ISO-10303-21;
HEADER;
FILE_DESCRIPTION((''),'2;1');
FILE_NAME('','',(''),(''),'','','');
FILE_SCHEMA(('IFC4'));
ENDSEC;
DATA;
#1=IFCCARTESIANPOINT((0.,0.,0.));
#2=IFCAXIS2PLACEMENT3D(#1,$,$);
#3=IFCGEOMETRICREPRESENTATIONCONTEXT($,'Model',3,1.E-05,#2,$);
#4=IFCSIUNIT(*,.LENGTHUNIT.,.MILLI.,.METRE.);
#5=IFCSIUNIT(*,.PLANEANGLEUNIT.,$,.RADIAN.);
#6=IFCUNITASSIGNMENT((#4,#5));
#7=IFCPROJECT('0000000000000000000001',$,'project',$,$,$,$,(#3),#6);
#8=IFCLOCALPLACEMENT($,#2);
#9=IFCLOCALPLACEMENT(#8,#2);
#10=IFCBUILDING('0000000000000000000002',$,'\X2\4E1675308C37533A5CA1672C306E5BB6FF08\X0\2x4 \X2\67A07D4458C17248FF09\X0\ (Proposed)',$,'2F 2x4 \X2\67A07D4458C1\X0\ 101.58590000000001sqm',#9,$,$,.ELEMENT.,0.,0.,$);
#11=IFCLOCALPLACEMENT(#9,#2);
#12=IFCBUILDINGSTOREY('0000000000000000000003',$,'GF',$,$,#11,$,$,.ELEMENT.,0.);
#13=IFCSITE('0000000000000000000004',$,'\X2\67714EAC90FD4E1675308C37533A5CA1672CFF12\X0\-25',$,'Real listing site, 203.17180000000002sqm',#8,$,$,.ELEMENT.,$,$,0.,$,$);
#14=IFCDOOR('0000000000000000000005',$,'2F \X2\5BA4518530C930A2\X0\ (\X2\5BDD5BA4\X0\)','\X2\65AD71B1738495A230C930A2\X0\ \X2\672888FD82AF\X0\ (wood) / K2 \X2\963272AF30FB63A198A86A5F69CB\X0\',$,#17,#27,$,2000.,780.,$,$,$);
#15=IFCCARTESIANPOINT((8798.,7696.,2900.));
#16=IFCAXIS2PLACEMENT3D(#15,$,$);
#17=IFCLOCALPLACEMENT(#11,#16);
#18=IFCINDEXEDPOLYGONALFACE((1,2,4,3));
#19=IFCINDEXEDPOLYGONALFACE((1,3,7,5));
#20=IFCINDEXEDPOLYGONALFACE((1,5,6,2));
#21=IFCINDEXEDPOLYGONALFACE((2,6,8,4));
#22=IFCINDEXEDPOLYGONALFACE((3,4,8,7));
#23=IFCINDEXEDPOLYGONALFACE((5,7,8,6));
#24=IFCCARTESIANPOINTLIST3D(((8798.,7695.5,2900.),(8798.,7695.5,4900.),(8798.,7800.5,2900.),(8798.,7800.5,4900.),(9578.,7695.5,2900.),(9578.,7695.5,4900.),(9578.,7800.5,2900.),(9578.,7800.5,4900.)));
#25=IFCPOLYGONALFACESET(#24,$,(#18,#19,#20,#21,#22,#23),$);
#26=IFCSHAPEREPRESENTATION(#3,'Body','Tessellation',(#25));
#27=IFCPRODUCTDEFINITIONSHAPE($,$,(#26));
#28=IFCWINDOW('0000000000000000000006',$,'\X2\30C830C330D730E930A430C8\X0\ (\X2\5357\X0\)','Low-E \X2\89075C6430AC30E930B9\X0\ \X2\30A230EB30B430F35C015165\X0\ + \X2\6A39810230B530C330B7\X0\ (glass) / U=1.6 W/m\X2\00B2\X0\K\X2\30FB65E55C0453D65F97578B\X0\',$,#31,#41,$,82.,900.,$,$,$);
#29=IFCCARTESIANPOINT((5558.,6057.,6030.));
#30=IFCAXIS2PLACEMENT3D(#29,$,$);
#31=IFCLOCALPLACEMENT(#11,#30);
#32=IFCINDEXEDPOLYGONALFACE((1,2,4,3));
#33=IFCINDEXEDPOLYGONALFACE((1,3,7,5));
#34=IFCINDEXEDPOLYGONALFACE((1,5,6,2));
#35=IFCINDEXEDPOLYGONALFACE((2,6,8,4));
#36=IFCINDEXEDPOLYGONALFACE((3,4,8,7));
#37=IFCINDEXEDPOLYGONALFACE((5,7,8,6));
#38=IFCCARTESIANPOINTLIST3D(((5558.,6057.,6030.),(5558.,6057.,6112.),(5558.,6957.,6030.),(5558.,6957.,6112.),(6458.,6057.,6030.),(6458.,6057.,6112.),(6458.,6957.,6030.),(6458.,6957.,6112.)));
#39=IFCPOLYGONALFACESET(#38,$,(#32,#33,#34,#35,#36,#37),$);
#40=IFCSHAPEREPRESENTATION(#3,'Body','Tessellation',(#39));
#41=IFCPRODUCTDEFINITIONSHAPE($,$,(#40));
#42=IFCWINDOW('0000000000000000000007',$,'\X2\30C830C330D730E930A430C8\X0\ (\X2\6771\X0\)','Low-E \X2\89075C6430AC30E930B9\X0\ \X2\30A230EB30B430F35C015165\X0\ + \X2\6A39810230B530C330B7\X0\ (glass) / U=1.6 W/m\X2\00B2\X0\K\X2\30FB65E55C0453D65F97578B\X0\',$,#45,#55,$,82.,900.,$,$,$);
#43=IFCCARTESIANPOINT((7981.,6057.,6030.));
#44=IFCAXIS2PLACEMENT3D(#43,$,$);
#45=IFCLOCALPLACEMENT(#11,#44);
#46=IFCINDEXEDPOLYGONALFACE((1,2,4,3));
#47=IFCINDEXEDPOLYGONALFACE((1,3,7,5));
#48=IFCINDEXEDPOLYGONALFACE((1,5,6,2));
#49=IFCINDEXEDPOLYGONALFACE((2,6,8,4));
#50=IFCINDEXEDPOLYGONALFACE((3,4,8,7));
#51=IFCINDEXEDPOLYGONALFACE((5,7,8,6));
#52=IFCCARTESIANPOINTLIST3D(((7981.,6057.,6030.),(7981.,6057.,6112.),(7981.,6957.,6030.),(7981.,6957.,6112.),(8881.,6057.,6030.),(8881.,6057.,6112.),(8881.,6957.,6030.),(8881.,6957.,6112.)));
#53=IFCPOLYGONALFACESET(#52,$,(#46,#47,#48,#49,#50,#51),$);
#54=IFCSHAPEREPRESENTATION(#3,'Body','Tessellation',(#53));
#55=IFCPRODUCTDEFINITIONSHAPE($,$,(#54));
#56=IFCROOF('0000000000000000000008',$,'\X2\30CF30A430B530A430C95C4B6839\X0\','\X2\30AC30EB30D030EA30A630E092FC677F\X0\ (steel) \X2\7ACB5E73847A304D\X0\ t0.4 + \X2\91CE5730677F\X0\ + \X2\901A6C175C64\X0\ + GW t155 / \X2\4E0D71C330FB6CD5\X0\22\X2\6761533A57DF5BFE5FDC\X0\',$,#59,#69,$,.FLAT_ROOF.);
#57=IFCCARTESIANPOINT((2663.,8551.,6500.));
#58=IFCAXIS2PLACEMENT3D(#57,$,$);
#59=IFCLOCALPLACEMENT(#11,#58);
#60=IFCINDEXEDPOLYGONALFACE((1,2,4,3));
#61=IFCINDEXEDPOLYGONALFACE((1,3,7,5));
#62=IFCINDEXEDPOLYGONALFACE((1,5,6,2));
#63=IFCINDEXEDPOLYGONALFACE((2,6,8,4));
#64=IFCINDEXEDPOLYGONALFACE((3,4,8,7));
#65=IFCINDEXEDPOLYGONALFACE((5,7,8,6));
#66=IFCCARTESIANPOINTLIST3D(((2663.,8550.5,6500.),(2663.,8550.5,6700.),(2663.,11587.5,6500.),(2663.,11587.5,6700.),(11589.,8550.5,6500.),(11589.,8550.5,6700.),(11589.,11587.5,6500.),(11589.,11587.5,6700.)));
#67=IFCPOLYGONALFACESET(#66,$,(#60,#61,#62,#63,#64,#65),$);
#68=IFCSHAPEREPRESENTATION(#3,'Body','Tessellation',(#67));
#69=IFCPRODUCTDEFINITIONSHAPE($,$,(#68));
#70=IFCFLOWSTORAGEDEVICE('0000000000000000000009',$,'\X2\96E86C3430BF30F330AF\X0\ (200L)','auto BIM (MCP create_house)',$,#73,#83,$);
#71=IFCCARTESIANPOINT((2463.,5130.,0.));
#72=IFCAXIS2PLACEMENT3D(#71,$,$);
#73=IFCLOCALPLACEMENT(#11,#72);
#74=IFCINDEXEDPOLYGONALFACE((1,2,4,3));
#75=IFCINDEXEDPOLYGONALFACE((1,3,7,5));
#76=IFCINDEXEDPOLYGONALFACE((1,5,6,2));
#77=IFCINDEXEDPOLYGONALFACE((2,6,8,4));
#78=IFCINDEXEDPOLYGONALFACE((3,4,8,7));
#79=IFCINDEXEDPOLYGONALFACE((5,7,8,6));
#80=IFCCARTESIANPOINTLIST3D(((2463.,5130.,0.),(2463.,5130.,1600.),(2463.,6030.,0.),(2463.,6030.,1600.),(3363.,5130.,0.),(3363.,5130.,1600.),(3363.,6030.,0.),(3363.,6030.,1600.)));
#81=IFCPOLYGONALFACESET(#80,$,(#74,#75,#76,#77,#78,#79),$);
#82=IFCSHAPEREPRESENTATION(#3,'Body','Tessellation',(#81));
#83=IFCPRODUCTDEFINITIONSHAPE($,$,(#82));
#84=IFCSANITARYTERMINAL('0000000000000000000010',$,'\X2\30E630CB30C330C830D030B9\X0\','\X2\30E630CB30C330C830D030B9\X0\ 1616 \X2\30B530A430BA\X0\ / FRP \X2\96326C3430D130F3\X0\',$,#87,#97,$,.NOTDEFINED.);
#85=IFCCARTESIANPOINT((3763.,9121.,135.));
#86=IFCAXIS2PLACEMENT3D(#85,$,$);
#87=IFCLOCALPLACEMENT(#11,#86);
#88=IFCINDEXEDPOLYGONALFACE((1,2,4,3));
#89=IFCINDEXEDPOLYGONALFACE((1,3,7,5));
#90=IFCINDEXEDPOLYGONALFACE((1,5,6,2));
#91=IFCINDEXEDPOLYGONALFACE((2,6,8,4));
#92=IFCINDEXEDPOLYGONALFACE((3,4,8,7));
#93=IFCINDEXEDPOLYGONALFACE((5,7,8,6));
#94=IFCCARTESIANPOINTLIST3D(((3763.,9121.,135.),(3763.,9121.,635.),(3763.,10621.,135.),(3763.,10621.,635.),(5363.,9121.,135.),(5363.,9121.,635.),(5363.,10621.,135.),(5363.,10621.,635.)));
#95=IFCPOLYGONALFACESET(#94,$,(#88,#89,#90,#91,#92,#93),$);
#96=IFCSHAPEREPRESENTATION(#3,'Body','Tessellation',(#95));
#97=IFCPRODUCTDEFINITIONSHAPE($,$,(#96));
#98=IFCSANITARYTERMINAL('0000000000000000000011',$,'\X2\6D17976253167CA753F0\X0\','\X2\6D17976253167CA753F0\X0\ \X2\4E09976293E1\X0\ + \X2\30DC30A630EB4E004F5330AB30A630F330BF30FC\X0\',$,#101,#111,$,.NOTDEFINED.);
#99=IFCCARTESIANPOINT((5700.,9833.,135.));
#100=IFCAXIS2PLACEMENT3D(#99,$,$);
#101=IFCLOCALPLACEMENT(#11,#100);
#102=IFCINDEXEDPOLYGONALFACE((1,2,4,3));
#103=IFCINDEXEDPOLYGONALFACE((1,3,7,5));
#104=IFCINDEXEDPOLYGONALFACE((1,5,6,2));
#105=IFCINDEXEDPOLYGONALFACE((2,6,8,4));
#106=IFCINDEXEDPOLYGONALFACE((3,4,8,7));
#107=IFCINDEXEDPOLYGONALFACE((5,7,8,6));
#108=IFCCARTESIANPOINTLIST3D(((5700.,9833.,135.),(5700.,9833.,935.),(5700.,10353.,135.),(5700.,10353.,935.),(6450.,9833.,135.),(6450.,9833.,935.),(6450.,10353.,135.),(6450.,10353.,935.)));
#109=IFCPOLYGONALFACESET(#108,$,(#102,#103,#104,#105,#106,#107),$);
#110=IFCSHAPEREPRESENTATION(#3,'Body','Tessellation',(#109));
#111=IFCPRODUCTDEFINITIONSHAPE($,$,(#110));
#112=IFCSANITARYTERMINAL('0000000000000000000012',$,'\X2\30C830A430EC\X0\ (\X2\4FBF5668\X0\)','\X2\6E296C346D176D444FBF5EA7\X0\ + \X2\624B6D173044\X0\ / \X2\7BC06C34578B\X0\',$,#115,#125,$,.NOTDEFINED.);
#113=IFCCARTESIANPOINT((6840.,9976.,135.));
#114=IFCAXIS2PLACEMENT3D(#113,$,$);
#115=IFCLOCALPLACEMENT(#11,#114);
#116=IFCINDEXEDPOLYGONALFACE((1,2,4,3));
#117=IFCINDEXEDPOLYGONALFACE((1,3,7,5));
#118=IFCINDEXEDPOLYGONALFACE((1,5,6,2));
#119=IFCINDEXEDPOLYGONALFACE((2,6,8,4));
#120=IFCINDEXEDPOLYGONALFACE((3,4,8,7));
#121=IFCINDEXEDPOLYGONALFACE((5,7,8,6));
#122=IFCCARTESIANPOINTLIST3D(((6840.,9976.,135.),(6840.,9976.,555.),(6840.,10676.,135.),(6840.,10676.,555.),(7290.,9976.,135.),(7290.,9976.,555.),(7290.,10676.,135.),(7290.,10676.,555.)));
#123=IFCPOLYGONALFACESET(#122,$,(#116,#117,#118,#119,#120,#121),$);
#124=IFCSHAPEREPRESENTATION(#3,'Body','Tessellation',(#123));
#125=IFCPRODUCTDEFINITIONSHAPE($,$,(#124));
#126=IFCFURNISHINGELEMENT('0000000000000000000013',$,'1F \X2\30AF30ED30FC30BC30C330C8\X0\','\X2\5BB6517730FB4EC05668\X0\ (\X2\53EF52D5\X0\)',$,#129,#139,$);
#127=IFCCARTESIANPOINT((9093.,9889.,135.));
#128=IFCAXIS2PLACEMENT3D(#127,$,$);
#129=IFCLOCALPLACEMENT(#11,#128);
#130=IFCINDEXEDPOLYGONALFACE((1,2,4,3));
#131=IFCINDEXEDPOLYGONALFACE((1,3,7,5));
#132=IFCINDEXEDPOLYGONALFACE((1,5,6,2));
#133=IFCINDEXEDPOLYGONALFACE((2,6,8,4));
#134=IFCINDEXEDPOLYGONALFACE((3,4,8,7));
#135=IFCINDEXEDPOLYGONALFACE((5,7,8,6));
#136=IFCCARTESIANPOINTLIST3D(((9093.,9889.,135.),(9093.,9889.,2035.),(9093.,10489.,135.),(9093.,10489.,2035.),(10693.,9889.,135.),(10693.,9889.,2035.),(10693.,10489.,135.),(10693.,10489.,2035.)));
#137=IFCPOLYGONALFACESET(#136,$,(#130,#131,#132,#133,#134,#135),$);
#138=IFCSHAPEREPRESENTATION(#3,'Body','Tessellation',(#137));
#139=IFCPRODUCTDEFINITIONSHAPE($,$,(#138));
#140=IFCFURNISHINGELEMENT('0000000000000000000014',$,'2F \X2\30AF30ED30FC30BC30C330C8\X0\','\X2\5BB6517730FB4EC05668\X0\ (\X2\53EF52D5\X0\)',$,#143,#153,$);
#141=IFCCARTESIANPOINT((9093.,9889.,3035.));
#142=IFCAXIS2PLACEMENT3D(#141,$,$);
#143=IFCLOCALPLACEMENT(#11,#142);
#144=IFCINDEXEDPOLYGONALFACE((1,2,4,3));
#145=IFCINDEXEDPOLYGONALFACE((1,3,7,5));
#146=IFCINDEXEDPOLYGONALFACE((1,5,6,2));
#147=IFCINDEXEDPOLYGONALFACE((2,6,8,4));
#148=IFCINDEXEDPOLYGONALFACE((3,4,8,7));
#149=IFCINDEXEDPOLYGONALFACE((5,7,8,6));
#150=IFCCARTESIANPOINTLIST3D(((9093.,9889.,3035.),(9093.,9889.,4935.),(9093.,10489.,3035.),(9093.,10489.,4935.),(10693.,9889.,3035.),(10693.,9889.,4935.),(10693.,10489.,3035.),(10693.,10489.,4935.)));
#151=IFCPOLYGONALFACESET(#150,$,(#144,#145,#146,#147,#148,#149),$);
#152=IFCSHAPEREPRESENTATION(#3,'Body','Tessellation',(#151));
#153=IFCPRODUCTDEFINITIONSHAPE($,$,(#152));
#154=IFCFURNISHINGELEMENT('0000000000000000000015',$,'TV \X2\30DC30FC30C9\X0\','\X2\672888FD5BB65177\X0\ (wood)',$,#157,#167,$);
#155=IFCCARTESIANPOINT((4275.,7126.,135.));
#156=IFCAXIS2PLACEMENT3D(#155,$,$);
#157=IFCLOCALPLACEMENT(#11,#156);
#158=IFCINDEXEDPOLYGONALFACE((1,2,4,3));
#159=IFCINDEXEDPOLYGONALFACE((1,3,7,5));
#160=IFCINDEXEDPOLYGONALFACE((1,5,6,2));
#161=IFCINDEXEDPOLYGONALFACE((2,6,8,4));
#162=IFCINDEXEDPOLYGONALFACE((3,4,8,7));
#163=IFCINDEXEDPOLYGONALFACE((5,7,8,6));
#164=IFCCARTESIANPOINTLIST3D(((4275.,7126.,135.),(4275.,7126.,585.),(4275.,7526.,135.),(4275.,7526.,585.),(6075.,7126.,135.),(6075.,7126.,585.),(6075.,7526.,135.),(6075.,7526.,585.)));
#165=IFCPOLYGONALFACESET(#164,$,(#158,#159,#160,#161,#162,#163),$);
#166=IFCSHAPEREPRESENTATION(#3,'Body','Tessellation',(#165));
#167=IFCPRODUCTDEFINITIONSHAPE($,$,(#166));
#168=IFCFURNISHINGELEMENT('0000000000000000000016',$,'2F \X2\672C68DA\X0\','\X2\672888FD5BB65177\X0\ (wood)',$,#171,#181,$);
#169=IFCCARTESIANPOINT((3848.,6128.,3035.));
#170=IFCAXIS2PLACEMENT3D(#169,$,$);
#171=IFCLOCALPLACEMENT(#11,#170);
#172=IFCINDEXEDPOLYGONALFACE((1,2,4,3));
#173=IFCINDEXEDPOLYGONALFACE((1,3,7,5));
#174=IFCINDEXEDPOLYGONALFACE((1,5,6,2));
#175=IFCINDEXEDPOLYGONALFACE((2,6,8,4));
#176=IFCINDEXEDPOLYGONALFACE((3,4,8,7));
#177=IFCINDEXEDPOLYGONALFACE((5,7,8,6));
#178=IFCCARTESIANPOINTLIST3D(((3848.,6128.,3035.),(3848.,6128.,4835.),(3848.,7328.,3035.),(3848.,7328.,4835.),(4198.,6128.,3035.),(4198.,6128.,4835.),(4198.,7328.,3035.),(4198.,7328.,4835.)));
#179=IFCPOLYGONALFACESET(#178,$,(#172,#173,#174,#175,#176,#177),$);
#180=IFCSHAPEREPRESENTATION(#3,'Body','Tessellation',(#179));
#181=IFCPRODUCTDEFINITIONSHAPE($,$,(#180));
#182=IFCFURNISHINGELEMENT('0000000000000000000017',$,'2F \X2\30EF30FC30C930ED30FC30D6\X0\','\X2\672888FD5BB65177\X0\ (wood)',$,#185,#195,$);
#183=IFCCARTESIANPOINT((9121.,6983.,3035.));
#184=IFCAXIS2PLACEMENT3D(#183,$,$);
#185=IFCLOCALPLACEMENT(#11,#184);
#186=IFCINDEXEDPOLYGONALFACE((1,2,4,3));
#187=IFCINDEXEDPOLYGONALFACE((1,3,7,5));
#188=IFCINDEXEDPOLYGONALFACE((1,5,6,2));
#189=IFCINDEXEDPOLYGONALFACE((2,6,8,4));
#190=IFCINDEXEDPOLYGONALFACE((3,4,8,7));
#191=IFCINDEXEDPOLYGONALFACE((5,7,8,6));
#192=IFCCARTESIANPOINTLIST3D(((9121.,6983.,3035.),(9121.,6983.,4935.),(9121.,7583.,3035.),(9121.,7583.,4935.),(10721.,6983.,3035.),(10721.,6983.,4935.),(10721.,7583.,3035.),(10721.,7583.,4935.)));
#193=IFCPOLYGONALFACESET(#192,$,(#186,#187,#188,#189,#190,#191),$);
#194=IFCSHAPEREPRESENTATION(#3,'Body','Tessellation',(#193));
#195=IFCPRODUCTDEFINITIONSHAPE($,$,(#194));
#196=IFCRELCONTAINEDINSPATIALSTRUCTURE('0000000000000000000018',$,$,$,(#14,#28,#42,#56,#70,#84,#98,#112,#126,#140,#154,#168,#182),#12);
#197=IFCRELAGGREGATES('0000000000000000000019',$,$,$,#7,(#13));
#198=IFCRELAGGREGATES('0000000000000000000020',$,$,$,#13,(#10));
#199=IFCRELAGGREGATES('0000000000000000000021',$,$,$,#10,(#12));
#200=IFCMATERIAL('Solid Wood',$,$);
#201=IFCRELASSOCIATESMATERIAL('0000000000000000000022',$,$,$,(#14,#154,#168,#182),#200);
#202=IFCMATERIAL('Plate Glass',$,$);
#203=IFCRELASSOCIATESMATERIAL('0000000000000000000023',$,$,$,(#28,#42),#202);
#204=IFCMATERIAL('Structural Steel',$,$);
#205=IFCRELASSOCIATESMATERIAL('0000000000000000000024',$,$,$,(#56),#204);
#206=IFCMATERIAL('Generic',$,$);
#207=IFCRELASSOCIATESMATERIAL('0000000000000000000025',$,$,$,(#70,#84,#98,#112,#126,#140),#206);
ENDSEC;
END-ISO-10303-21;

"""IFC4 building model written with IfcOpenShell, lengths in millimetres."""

from ifc_helpers import new_model, si_unit, frame, frame_2d, origin, place, context, project, spatial, rectangle, extrude, material, element, save


model = new_model("IFC4")

# Units and contexts
model_context = context("Model", 3, precision=1e-05, world=origin())
ifc_project = project(units=[si_unit("LENGTHUNIT", "METRE", prefix="MILLI"), si_unit("PLANEANGLEUNIT", "RADIAN")], contexts=[model_context])

# Site, building, storey
site_placement = place(None, origin())
site = spatial("IfcSite", under=ifc_project, at=site_placement, Name="東京都世田谷区岡本２-25", ObjectType="Real listing site, 203.17180000000002sqm", CompositionType="ELEMENT", RefElevation=0.0)
building_placement = place(site_placement, origin())
building = spatial("IfcBuilding", under=site, at=building_placement, Name="世田谷区岡本の家（2x4 枠組壁版） (Proposed)", ObjectType="2F 2x4 枠組壁 101.58590000000001sqm", CompositionType="ELEMENT", ElevationOfRefHeight=0.0, ElevationOfTerrain=0.0)
storey_placement = place(building_placement, origin())
storey = spatial("IfcBuildingStorey", under=building, at=storey_placement, Name="GF", CompositionType="ELEMENT", Elevation=0.0)

# Shared definitions
ifc_material_1 = material(Name="Solid Wood")
ifc_material_2 = material(Name="Plate Glass")

# Door
door_1_placement = place(storey_placement, frame((8798.0, 7696.0, 2900.0)))
element("IfcDoor", 1, at=door_1_placement, inside=storey, material=ifc_material_1, Name="2F 室内ドア (寝室)", Description="断熱玄関ドア 木製芯 (wood) / K2 防犯・採風機構", OverallHeight=2000.0, OverallWidth=780.0, context=model_context, shape_type="SweptSolid", body=[
    extrude(rectangle(XDim=780.0, YDim=105.0, at=frame_2d((390.0, 52.0))), frame((8798.0, 7696.0, 2900.0)), (0.0, 0.0, 1.0), 2000.0),
])

# Windows
window_1_placement = place(storey_placement, frame((5558.0, 6057.0, 6030.0)))
element("IfcWindow", 2, at=window_1_placement, inside=storey, material=ifc_material_2, Name="トップライト (南)", Description="Low-E 複層ガラス アルゴン封入 + 樹脂サッシ (glass) / U=1.6 W/m²K・日射取得型", OverallHeight=82.0, OverallWidth=900.0, context=model_context, shape_type="SweptSolid", body=[
    extrude(rectangle(XDim=900.0, YDim=900.0, at=frame_2d((450.0, 450.0))), frame((5558.0, 6057.0, 6030.0)), (0.0, 0.0, 1.0), 82.0),
])
window_2_placement = place(storey_placement, frame((7981.0, 6057.0, 6030.0)))
element("IfcWindow", 3, at=window_2_placement, inside=storey, material=ifc_material_2, Name="トップライト (東)", Description="Low-E 複層ガラス アルゴン封入 + 樹脂サッシ (glass) / U=1.6 W/m²K・日射取得型", OverallHeight=82.0, OverallWidth=900.0, context=model_context, shape_type="SweptSolid", body=[
    extrude(rectangle(XDim=900.0, YDim=900.0, at=frame_2d((450.0, 450.0))), frame((7981.0, 6057.0, 6030.0)), (0.0, 0.0, 1.0), 82.0),
])

# Roof
ifc_material_3 = material(Name="Structural Steel")
roof_placement = place(storey_placement, frame((2663.0, 8551.0, 6500.0)))
element("IfcRoof", 4, at=roof_placement, inside=storey, material=ifc_material_3, Name="ハイサイド屋根", Description="ガルバリウム鋼板 (steel) 立平葺き t0.4 + 野地板 + 通気層 + GW t155 / 不燃・法22条区域対応", PredefinedType="FLAT_ROOF", context=model_context, shape_type="SweptSolid", body=[
    extrude(rectangle(XDim=8926.0, YDim=3037.0, at=frame_2d((4463.0, 1518.0))), frame((2663.0, 8551.0, 6500.0)), (0.0, 0.0, 1.0), 200.0),
])

# Flow storage device
ifc_material_4 = material(Name="Generic")
flow_storage_device_placement = place(storey_placement, frame((2463.0, 5130.0, 0.0)))
element("IfcFlowStorageDevice", 5, at=flow_storage_device_placement, inside=storey, material=ifc_material_4, Name="雨水タンク (200L)", Description="auto BIM (MCP create_house)", context=model_context, shape_type="SweptSolid", body=[
    extrude(rectangle(XDim=900.0, YDim=900.0, at=frame_2d((450.0, 450.0))), frame((2463.0, 5130.0, 0.0)), (0.0, 0.0, 1.0), 1600.0),
])

# Sanitary terminals
sanitary_terminal_1_placement = place(storey_placement, frame((3763.0, 9121.0, 135.0)))
element("IfcSanitaryTerminal", 6, at=sanitary_terminal_1_placement, inside=storey, material=ifc_material_4, Name="ユニットバス", Description="ユニットバス 1616 サイズ / FRP 防水パン", PredefinedType="NOTDEFINED", context=model_context, shape_type="SweptSolid", body=[
    extrude(rectangle(XDim=1600.0, YDim=1500.0, at=frame_2d((800.0, 750.0))), frame((3763.0, 9121.0, 135.0)), (0.0, 0.0, 1.0), 500.0),
])
sanitary_terminal_2_placement = place(storey_placement, frame((5700.0, 9833.0, 135.0)))
element("IfcSanitaryTerminal", 7, at=sanitary_terminal_2_placement, inside=storey, material=ifc_material_4, Name="洗面化粧台", Description="洗面化粧台 三面鏡 + ボウル一体カウンター", PredefinedType="NOTDEFINED", context=model_context, shape_type="SweptSolid", body=[
    extrude(rectangle(XDim=750.0, YDim=520.0, at=frame_2d((375.0, 260.0))), frame((5700.0, 9833.0, 135.0)), (0.0, 0.0, 1.0), 800.0),
])
sanitary_terminal_3_placement = place(storey_placement, frame((6840.0, 9976.0, 135.0)))
element("IfcSanitaryTerminal", 8, at=sanitary_terminal_3_placement, inside=storey, material=ifc_material_4, Name="トイレ (便器)", Description="温水洗浄便座 + 手洗い / 節水型", PredefinedType="NOTDEFINED", context=model_context, shape_type="SweptSolid", body=[
    extrude(rectangle(XDim=450.0, YDim=700.0, at=frame_2d((225.0, 350.0))), frame((6840.0, 9976.0, 135.0)), (0.0, 0.0, 1.0), 420.0),
])

# Furnishing elements
furnishing_1_placement = place(storey_placement, frame((9093.0, 9889.0, 135.0)))
element("IfcFurnishingElement", 9, at=furnishing_1_placement, inside=storey, material=ifc_material_4, Name="1F クローゼット", Description="家具・什器 (可動)", context=model_context, shape_type="SweptSolid", body=[
    extrude(rectangle(XDim=1600.0, YDim=600.0, at=frame_2d((800.0, 300.0))), frame((9093.0, 9889.0, 135.0)), (0.0, 0.0, 1.0), 1900.0),
])
furnishing_2_placement = place(storey_placement, frame((9093.0, 9889.0, 3035.0)))
element("IfcFurnishingElement", 10, at=furnishing_2_placement, inside=storey, material=ifc_material_4, Name="2F クローゼット", Description="家具・什器 (可動)", context=model_context, shape_type="SweptSolid", body=[
    extrude(rectangle(XDim=1600.0, YDim=600.0, at=frame_2d((800.0, 300.0))), frame((9093.0, 9889.0, 3035.0)), (0.0, 0.0, 1.0), 1900.0),
])
furnishing_3_placement = place(storey_placement, frame((4275.0, 7126.0, 135.0)))
element("IfcFurnishingElement", 11, at=furnishing_3_placement, inside=storey, material=ifc_material_1, Name="TV ボード", Description="木製家具 (wood)", context=model_context, shape_type="SweptSolid", body=[
    extrude(rectangle(XDim=1800.0, YDim=400.0, at=frame_2d((900.0, 200.0))), frame((4275.0, 7126.0, 135.0)), (0.0, 0.0, 1.0), 450.0),
])
furnishing_4_placement = place(storey_placement, frame((3848.0, 6128.0, 3035.0)))
element("IfcFurnishingElement", 12, at=furnishing_4_placement, inside=storey, material=ifc_material_1, Name="2F 本棚", Description="木製家具 (wood)", context=model_context, shape_type="SweptSolid", body=[
    extrude(rectangle(XDim=350.0, YDim=1200.0, at=frame_2d((175.0, 600.0))), frame((3848.0, 6128.0, 3035.0)), (0.0, 0.0, 1.0), 1800.0),
])
furnishing_5_placement = place(storey_placement, frame((9121.0, 6983.0, 3035.0)))
element("IfcFurnishingElement", 13, at=furnishing_5_placement, inside=storey, material=ifc_material_1, Name="2F ワードローブ", Description="木製家具 (wood)", context=model_context, shape_type="SweptSolid", body=[
    extrude(rectangle(XDim=1600.0, YDim=600.0, at=frame_2d((800.0, 300.0))), frame((9121.0, 6983.0, 3035.0)), (0.0, 0.0, 1.0), 1900.0),
])

save(model, "model.ifc")
